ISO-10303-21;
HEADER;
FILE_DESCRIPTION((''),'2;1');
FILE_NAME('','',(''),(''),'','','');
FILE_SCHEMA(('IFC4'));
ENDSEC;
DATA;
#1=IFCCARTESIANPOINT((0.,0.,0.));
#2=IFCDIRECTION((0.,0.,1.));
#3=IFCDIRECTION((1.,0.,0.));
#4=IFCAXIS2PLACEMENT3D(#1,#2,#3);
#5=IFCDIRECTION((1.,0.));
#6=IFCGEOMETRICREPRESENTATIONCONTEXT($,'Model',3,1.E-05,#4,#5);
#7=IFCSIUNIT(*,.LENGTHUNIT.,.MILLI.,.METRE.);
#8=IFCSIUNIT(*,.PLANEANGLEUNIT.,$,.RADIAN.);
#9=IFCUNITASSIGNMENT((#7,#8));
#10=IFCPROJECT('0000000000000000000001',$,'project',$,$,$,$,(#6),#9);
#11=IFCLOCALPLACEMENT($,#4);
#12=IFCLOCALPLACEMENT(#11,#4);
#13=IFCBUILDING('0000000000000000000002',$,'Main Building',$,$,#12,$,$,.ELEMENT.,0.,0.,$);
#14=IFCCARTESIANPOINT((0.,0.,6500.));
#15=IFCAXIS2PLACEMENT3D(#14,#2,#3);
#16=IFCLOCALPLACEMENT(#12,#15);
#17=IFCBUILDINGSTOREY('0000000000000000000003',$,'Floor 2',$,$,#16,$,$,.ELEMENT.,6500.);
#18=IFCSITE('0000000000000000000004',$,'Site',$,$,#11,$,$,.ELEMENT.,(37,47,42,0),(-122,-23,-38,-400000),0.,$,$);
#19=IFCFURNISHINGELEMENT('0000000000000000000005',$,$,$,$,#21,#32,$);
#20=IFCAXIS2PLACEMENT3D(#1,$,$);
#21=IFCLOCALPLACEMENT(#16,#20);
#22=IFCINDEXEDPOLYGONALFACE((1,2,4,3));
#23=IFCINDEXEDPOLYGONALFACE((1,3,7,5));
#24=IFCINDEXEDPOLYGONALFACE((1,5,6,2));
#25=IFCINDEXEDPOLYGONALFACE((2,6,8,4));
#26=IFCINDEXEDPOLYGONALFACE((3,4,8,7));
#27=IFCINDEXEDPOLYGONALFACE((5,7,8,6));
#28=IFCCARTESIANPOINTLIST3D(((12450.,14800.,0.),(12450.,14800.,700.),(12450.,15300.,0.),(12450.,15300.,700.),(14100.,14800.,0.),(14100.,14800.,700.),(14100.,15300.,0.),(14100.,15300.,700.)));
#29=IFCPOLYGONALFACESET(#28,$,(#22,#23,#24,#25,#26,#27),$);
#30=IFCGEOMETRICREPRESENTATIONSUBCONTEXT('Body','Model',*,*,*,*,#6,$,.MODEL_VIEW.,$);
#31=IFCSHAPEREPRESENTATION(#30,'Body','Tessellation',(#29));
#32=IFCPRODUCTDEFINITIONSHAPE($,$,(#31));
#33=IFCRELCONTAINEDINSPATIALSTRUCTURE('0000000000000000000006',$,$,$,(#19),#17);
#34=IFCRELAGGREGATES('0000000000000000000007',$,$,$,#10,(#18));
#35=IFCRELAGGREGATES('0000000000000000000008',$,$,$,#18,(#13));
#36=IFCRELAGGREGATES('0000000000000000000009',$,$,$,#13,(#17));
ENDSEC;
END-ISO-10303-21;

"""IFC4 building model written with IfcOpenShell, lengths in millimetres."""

from ifc_helpers import new_model, si_unit, direction, frame, origin_with_axes, origin_2d_with_axis, place, context, subcontext, project, spatial, rectangle, extrude, element, save


model = new_model("IFC4")

# Units and contexts
model_context = context("Model", 3, precision=1e-05, world=origin_with_axes(), true_north=direction((1.0, 0.0)))
body_context = subcontext(model_context, "Body", "Model", "MODEL_VIEW")
ifc_project = project(units=[si_unit("LENGTHUNIT", "METRE", prefix="MILLI"), si_unit("PLANEANGLEUNIT", "RADIAN")], contexts=[model_context])

# Site, building, storey
site_placement = place(None, origin_with_axes())
site = spatial("IfcSite", under=ifc_project, at=site_placement, Name="Site", CompositionType="ELEMENT", RefLatitude=(37, 47, 42, 0), RefLongitude=(-122, -23, -38, -400000), RefElevation=0.0)
building_placement = place(site_placement, origin_with_axes())
building = spatial("IfcBuilding", under=site, at=building_placement, Name="Main Building", CompositionType="ELEMENT", ElevationOfRefHeight=0.0, ElevationOfTerrain=0.0)
storey_placement = place(building_placement, frame((0.0, 0.0, 6500.0), z_axis=(0.0, 0.0, 1.0), x_axis=(1.0, 0.0, 0.0)))
storey = spatial("IfcBuildingStorey", under=building, at=storey_placement, Name="Floor 2", CompositionType="ELEMENT", Elevation=6500.0)

# Furnishing element
furnishing_placement = place(storey_placement, frame((12450.0, 14800.0, 0.0), z_axis=(0.0, 0.0, 1.0), x_axis=(1.0, 0.0, 0.0)))
element("IfcFurnishingElement", 1, at=furnishing_placement, inside=storey, context=body_context, shape_type="SweptSolid", body=[
    extrude(rectangle(XDim=1650.0, YDim=500.0, at=origin_2d_with_axis()), frame((825.0, 250.0, 0.0), z_axis=(0.0, 0.0, 1.0), x_axis=(1.0, 0.0, 0.0)), (0.0, 0.0, 1.0), 700.0),
])

save(model, "model.ifc")
